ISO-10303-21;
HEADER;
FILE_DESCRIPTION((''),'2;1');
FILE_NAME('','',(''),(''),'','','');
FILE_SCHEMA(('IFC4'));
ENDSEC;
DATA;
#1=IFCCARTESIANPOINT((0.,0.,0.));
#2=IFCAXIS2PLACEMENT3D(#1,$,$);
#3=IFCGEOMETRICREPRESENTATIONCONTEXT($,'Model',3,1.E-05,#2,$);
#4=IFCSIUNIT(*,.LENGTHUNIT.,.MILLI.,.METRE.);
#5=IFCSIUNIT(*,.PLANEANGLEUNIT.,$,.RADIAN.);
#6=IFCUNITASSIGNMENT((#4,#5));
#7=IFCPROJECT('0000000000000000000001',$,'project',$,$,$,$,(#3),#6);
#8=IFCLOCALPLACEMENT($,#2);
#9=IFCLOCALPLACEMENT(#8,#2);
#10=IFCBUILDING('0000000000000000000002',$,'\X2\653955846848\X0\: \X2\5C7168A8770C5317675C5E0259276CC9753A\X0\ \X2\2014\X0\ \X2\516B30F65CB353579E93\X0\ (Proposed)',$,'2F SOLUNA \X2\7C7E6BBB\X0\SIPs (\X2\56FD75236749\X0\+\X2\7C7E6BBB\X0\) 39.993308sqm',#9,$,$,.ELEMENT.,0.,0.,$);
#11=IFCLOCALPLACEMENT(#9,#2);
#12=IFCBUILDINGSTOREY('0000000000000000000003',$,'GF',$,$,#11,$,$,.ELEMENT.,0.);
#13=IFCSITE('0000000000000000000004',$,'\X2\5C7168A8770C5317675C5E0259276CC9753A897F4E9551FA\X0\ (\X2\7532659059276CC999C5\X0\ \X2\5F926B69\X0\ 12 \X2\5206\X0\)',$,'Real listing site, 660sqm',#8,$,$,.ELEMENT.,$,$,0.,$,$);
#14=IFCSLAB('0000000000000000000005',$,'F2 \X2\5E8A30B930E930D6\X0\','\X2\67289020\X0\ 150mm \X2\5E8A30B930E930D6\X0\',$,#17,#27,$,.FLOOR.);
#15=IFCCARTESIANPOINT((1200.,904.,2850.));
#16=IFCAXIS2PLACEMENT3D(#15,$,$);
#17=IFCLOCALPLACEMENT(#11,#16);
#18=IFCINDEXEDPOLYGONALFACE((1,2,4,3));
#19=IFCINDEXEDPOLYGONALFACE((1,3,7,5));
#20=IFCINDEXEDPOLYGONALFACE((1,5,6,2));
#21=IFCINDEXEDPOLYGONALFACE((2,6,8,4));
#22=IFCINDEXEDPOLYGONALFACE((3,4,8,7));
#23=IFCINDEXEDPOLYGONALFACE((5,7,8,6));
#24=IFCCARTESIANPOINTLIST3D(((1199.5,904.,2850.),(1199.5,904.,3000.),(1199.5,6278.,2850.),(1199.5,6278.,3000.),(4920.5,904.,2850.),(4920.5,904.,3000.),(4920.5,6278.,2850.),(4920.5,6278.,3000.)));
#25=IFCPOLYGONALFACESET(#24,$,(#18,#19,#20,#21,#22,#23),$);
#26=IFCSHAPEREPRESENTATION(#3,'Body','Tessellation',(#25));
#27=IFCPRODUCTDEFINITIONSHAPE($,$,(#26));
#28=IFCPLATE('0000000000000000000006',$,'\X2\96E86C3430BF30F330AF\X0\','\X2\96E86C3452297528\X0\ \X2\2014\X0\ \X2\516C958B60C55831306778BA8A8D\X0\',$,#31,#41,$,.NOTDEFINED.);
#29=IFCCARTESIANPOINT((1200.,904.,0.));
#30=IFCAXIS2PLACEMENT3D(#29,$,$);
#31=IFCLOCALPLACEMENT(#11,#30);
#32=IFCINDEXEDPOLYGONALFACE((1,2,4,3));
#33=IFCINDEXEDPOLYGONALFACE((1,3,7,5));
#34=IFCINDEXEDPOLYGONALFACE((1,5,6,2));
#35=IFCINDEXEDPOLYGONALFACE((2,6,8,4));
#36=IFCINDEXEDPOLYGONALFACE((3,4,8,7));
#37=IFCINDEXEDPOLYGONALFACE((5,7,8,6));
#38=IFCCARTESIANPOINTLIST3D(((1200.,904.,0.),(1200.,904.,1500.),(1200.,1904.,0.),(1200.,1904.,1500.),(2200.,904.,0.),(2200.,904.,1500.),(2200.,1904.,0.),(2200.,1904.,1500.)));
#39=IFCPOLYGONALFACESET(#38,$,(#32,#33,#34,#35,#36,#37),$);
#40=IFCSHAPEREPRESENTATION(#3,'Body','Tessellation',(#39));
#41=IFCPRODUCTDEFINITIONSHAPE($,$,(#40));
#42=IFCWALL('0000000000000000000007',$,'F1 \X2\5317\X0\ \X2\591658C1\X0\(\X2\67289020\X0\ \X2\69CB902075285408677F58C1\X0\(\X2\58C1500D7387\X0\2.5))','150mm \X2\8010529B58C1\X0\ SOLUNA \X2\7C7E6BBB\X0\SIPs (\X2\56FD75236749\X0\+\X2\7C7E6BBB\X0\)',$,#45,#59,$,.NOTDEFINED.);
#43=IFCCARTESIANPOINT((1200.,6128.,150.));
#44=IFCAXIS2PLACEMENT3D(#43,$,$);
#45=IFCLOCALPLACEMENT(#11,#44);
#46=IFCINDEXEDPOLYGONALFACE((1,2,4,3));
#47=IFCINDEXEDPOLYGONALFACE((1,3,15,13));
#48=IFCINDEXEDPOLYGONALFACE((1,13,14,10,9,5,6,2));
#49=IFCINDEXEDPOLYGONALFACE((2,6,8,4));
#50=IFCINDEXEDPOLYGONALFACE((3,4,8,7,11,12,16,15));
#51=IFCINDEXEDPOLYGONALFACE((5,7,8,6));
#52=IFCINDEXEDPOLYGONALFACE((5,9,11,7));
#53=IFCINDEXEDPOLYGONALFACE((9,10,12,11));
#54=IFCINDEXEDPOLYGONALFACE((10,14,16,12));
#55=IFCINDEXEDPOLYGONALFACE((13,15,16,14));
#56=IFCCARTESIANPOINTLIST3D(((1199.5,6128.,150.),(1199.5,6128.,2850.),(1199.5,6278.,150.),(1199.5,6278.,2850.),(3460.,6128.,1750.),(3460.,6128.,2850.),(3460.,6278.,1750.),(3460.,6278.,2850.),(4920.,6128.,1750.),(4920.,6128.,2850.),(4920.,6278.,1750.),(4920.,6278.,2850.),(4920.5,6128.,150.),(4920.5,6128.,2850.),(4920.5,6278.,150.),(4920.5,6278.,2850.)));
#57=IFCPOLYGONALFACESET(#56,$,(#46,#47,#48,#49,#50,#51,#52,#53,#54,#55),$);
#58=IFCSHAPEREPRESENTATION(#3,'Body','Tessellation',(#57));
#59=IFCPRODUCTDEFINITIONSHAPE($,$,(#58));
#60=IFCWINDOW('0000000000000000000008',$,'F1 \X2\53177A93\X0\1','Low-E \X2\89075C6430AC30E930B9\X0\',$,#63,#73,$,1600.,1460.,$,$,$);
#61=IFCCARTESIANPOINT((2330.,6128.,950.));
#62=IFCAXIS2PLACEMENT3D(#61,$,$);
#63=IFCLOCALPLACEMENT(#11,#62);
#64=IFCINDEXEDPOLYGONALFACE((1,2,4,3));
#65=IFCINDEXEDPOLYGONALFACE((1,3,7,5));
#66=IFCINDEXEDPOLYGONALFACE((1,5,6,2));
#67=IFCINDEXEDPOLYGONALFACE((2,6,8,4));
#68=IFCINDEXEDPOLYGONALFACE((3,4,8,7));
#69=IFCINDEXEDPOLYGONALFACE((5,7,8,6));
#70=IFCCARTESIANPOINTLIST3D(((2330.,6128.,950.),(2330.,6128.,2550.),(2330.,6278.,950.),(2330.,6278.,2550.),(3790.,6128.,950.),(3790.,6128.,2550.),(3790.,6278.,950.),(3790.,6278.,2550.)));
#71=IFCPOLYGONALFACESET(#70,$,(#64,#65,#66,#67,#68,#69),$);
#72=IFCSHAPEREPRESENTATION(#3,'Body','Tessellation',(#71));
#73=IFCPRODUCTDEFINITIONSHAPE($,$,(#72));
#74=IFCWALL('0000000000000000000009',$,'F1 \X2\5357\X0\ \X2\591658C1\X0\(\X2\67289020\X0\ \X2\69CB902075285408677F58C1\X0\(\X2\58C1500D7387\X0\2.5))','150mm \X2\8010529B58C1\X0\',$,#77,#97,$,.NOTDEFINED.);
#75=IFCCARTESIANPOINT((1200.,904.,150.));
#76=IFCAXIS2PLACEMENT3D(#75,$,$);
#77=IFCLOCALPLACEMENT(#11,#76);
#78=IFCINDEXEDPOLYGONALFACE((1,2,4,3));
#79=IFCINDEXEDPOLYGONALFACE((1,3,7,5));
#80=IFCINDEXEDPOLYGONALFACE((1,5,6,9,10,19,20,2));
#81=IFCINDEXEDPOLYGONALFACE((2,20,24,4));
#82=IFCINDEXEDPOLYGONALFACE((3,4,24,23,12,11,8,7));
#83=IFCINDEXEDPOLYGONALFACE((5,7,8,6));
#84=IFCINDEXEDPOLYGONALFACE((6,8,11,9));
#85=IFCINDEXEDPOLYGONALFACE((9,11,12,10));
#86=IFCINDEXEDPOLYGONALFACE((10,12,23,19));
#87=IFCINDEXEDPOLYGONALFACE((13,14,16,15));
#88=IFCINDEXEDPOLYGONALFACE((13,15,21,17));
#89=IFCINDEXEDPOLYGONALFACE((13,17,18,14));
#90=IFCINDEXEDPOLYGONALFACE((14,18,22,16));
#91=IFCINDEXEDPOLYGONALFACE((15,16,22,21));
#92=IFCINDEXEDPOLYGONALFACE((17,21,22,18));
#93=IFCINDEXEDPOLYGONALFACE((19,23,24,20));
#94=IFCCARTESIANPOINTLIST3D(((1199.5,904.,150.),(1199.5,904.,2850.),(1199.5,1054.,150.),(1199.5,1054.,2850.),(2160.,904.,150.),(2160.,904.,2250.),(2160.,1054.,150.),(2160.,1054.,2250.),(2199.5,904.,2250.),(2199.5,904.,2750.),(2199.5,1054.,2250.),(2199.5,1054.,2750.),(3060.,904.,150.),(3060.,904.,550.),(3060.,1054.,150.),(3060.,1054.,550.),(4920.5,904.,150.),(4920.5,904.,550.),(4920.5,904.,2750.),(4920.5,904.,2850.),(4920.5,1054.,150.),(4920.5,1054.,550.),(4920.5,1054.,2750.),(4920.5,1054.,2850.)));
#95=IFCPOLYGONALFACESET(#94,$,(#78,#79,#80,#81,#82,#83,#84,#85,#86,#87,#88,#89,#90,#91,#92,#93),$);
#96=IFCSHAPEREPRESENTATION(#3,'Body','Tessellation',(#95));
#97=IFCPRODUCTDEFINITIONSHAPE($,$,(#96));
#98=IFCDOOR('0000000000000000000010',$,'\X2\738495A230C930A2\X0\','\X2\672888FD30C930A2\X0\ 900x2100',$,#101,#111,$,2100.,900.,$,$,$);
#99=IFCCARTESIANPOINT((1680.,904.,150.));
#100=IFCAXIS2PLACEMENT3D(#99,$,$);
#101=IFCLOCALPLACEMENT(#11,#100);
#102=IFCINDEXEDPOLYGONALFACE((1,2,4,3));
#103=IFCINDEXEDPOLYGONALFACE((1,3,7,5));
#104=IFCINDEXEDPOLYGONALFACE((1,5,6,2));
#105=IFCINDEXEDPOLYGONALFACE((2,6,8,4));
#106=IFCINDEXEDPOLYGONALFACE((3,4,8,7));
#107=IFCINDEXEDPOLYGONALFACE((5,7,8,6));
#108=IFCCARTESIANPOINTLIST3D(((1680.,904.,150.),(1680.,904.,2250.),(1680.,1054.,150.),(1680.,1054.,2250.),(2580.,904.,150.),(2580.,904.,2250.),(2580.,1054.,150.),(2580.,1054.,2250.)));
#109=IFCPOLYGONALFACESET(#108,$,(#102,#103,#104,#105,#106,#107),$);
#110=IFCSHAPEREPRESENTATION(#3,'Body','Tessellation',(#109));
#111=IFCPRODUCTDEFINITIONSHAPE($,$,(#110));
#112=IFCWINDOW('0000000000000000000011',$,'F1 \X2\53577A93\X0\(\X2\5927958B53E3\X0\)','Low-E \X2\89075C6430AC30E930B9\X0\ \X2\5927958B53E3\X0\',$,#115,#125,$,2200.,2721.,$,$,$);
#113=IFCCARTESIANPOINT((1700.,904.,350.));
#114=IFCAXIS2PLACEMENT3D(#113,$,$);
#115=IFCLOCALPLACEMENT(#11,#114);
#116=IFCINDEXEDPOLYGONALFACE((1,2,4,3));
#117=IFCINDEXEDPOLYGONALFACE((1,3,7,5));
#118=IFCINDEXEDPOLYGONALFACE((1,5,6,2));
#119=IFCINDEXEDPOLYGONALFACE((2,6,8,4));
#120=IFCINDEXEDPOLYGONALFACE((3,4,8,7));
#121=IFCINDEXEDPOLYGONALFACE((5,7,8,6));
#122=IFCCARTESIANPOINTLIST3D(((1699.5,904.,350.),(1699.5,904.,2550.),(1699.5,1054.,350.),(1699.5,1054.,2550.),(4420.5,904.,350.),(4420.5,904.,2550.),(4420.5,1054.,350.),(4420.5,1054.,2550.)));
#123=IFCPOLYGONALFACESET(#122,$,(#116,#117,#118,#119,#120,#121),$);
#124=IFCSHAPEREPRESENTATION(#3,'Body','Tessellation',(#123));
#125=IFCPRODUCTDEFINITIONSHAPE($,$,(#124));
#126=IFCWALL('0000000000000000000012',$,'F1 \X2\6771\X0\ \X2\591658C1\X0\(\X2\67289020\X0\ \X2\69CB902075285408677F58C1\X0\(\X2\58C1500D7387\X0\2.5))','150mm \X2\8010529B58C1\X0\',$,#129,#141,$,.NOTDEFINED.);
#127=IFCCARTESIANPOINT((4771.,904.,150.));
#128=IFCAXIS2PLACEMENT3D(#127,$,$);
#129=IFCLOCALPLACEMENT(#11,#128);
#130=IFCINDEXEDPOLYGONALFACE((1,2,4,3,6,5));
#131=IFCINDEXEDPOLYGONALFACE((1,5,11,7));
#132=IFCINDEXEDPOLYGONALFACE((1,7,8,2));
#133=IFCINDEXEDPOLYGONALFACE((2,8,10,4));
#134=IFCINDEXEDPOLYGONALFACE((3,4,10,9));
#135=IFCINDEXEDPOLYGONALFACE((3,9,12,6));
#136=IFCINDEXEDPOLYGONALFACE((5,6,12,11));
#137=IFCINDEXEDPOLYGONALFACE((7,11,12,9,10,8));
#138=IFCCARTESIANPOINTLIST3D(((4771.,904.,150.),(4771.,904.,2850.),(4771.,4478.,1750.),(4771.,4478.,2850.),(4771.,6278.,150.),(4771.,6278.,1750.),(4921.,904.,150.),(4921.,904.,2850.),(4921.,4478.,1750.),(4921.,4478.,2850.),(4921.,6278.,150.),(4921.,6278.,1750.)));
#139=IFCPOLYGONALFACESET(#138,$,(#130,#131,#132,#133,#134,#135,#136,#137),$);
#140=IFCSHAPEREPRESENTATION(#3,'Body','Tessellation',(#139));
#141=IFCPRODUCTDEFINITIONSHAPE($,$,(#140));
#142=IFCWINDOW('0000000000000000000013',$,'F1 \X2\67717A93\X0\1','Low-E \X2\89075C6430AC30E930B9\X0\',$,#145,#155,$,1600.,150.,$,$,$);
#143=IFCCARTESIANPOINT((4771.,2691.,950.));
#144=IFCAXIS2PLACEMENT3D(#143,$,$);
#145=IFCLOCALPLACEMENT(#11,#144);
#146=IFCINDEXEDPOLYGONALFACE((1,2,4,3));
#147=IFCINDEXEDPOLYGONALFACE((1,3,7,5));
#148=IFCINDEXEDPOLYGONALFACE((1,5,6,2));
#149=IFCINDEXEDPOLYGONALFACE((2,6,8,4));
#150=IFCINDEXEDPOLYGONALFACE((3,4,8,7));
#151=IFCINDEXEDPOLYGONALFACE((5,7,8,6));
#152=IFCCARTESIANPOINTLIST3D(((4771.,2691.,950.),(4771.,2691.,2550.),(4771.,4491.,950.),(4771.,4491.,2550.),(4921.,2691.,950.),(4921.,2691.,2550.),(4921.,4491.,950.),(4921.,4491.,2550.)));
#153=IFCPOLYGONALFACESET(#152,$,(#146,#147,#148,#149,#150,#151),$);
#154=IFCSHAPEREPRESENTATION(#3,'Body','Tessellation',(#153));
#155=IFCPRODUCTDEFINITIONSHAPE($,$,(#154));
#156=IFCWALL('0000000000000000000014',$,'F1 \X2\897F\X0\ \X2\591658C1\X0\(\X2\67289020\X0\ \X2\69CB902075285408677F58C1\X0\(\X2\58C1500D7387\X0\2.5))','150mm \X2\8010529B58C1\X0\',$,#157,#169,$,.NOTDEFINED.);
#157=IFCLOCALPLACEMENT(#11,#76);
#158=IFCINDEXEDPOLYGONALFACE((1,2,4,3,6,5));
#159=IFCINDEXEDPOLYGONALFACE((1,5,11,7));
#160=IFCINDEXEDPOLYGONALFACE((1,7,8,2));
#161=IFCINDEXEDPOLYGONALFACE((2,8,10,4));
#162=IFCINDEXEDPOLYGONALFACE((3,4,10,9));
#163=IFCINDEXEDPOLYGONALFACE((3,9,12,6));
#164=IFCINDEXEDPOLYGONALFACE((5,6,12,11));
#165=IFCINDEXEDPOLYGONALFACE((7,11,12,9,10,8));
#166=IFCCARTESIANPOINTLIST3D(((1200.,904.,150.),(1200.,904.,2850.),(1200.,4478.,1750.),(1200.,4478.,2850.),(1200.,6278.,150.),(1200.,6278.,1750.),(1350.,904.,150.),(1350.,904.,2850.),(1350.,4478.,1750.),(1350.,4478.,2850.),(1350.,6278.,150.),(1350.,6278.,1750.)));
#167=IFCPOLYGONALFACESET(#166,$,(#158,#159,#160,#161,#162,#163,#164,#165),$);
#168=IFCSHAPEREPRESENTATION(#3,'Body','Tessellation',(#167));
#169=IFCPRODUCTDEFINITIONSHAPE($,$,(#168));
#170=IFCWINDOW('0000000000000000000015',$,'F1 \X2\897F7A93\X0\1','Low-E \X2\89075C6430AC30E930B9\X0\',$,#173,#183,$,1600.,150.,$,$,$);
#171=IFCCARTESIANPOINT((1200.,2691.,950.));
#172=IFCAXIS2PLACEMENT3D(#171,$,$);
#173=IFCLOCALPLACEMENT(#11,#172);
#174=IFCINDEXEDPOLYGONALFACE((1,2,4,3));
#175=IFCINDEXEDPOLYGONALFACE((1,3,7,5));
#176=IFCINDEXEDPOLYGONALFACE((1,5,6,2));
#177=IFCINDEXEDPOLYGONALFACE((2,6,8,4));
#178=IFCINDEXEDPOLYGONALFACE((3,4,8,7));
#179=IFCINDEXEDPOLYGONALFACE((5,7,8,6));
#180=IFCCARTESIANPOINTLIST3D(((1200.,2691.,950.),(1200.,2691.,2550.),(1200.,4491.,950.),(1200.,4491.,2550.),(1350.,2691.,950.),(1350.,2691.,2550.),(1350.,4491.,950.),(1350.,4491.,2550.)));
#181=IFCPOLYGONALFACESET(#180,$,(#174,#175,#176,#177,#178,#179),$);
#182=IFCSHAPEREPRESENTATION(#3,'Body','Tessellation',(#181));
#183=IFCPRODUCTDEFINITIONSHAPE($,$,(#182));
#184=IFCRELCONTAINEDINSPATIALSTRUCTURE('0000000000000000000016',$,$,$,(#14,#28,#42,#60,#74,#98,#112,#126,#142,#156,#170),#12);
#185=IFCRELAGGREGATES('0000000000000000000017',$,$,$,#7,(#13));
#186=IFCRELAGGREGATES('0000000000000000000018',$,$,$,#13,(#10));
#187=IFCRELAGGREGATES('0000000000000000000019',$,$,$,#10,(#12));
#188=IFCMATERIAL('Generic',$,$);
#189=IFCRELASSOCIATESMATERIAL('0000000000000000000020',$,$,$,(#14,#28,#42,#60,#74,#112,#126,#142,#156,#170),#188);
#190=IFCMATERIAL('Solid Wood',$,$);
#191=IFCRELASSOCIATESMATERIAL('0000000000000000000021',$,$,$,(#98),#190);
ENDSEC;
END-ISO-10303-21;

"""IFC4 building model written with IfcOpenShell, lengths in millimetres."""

from ifc_helpers import new_model, si_unit, frame, frame_2d, origin, place, context, project, spatial, rectangle, extrude, material, element, fill, save


model = new_model("IFC4")

# Units and contexts
model_context = context("Model", 3, precision=1e-05, world=origin())
ifc_project = project(units=[si_unit("LENGTHUNIT", "METRE", prefix="MILLI"), si_unit("PLANEANGLEUNIT", "RADIAN")], contexts=[model_context])

# Site, building, storey
site_placement = place(None, origin())
site = spatial("IfcSite", under=ifc_project, at=site_placement, Name="山梨県北杜市大泉町西井出 (甲斐大泉駅 徒歩 12 分)", ObjectType="Real listing site, 660sqm", CompositionType="ELEMENT", RefElevation=0.0)
building_placement = place(site_placement, origin())
building = spatial("IfcBuilding", under=site, at=building_placement, Name="改善案: 山梨県北杜市大泉町 — 八ヶ岳南麓 (Proposed)", ObjectType="2F SOLUNA 籾殻SIPs (国産杉+籾殻) 39.993308sqm", CompositionType="ELEMENT", ElevationOfRefHeight=0.0, ElevationOfTerrain=0.0)
storey_placement = place(building_placement, origin())
storey = spatial("IfcBuildingStorey", under=building, at=storey_placement, Name="GF", CompositionType="ELEMENT", Elevation=0.0)

# Slab
ifc_material_1 = material(Name="Generic")
slab_1_placement = place(storey_placement, frame((1200.0, 904.0, 2850.0)))
element("IfcSlab", 1, at=slab_1_placement, inside=storey, material=ifc_material_1, Name="F2 床スラブ", Description="木造 150mm 床スラブ", PredefinedType="FLOOR", context=model_context, shape_type="SweptSolid", body=[
    extrude(rectangle(XDim=3721.0, YDim=5374.0, at=frame_2d((1860.0, 2687.0))), frame((1200.0, 904.0, 2850.0)), (0.0, 0.0, 1.0), 150.0),
])

# Plate
plate_placement = place(storey_placement, frame((1200.0, 904.0, 0.0)))
element("IfcPlate", 2, at=plate_placement, inside=storey, material=ifc_material_1, Name="雨水タンク", Description="雨水利用 — 公開情報で確認", PredefinedType="NOTDEFINED", context=model_context, shape_type="SweptSolid", body=[
    extrude(rectangle(XDim=1000.0, YDim=1000.0, at=frame_2d((500.0, 500.0))), frame((1200.0, 904.0, 0.0)), (0.0, 0.0, 1.0), 1500.0),
])

# Wall, opening, window
wall_1_placement = place(storey_placement, frame((1200.0, 6128.0, 150.0)))
wall_1 = element("IfcWall", 3, at=wall_1_placement, inside=storey, material=ifc_material_1, Name="F1 北 外壁(木造 構造用合板壁(壁倍率2.5))", Description="150mm 耐力壁 SOLUNA 籾殻SIPs (国産杉+籾殻)", PredefinedType="NOTDEFINED", context=model_context, shape_type="SweptSolid", body=[
    extrude(rectangle(XDim=3721.0, YDim=150.0, at=frame_2d((1860.0, 75.0))), frame((1200.0, 6128.0, 150.0)), (0.0, 0.0, 1.0), 2700.0),
])
opening_1_placement = place(storey_placement, frame((2330.0, 6128.0, 950.0)))
opening_1 = element("IfcOpeningElement", 4, at=opening_1_placement, cuts=wall_1, PredefinedType="NOTDEFINED", context=model_context, shape_type="SweptSolid", body=[
    extrude(rectangle(XDim=1460.0, YDim=150.0, at=frame_2d((730.0, 75.0))), frame((2330.0, 6128.0, 950.0)), (0.0, 0.0, 1.0), 1600.0),
])
window_1_placement = place(storey_placement, frame((2330.0, 6128.0, 950.0)))
window_1 = element("IfcWindow", 5, at=window_1_placement, inside=storey, material=ifc_material_1, Name="F1 北窓1", Description="Low-E 複層ガラス", OverallHeight=1600.0, OverallWidth=1460.0, context=model_context, shape_type="SweptSolid", body=[
    extrude(rectangle(XDim=1460.0, YDim=150.0, at=frame_2d((730.0, 75.0))), frame((2330.0, 6128.0, 950.0)), (0.0, 0.0, 1.0), 1600.0),
])
fill(opening_1, window_1)

# Wall, openings, door, window
wall_2_placement = place(storey_placement, frame((1200.0, 904.0, 150.0)))
wall_2 = element("IfcWall", 6, at=wall_2_placement, inside=storey, material=ifc_material_1, Name="F1 南 外壁(木造 構造用合板壁(壁倍率2.5))", Description="150mm 耐力壁", PredefinedType="NOTDEFINED", context=model_context, shape_type="SweptSolid", body=[
    extrude(rectangle(XDim=3721.0, YDim=150.0, at=frame_2d((1860.0, 75.0))), frame((1200.0, 904.0, 150.0)), (0.0, 0.0, 1.0), 2700.0),
])
opening_2_placement = place(storey_placement, frame((1680.0, 904.0, 150.0)))
opening_2 = element("IfcOpeningElement", 7, at=opening_2_placement, cuts=wall_2, PredefinedType="NOTDEFINED", context=model_context, shape_type="SweptSolid", body=[
    extrude(rectangle(XDim=900.0, YDim=150.0, at=frame_2d((450.0, 75.0))), frame((1680.0, 904.0, 150.0)), (0.0, 0.0, 1.0), 2100.0),
])
opening_3_placement = place(storey_placement, frame((1700.0, 904.0, 350.0)))
opening_3 = element("IfcOpeningElement", 8, at=opening_3_placement, cuts=wall_2, PredefinedType="NOTDEFINED", context=model_context, shape_type="SweptSolid", body=[
    extrude(rectangle(XDim=2721.0, YDim=150.0, at=frame_2d((1360.0, 75.0))), frame((1700.0, 904.0, 350.0)), (0.0, 0.0, 1.0), 2200.0),
])
ifc_material_2 = material(Name="Solid Wood")
door_placement = place(storey_placement, frame((1680.0, 904.0, 150.0)))
door = element("IfcDoor", 9, at=door_placement, inside=storey, material=ifc_material_2, Name="玄関ドア", Description="木製ドア 900x2100", OverallHeight=2100.0, OverallWidth=900.0, context=model_context, shape_type="SweptSolid", body=[
    extrude(rectangle(XDim=900.0, YDim=150.0, at=frame_2d((450.0, 75.0))), frame((1680.0, 904.0, 150.0)), (0.0, 0.0, 1.0), 2100.0),
])
fill(opening_2, door)
window_2_placement = place(storey_placement, frame((1700.0, 904.0, 350.0)))
window_2 = element("IfcWindow", 10, at=window_2_placement, inside=storey, material=ifc_material_1, Name="F1 南窓(大開口)", Description="Low-E 複層ガラス 大開口", OverallHeight=2200.0, OverallWidth=2721.0, context=model_context, shape_type="SweptSolid", body=[
    extrude(rectangle(XDim=2721.0, YDim=150.0, at=frame_2d((1360.0, 75.0))), frame((1700.0, 904.0, 350.0)), (0.0, 0.0, 1.0), 2200.0),
])
fill(opening_3, window_2)

# Walls, openings, windows
wall_3_placement = place(storey_placement, frame((4771.0, 904.0, 150.0)))
wall_3 = element("IfcWall", 11, at=wall_3_placement, inside=storey, material=ifc_material_1, Name="F1 東 外壁(木造 構造用合板壁(壁倍率2.5))", Description="150mm 耐力壁", PredefinedType="NOTDEFINED", context=model_context, shape_type="SweptSolid", body=[
    extrude(rectangle(XDim=150.0, YDim=5374.0, at=frame_2d((75.0, 2687.0))), frame((4771.0, 904.0, 150.0)), (0.0, 0.0, 1.0), 2700.0),
])
opening_4_placement = place(storey_placement, frame((4771.0, 2691.0, 950.0)))
opening_4 = element("IfcOpeningElement", 12, at=opening_4_placement, cuts=wall_3, PredefinedType="NOTDEFINED", context=model_context, shape_type="SweptSolid", body=[
    extrude(rectangle(XDim=150.0, YDim=1800.0, at=frame_2d((75.0, 900.0))), frame((4771.0, 2691.0, 950.0)), (0.0, 0.0, 1.0), 1600.0),
])
window_3_placement = place(storey_placement, frame((4771.0, 2691.0, 950.0)))
window_3 = element("IfcWindow", 13, at=window_3_placement, inside=storey, material=ifc_material_1, Name="F1 東窓1", Description="Low-E 複層ガラス", OverallHeight=1600.0, OverallWidth=150.0, context=model_context, shape_type="SweptSolid", body=[
    extrude(rectangle(XDim=150.0, YDim=1800.0, at=frame_2d((75.0, 900.0))), frame((4771.0, 2691.0, 950.0)), (0.0, 0.0, 1.0), 1600.0),
])
fill(opening_4, window_3)
wall_4_placement = place(storey_placement, frame((1200.0, 904.0, 150.0)))
wall_4 = element("IfcWall", 14, at=wall_4_placement, inside=storey, material=ifc_material_1, Name="F1 西 外壁(木造 構造用合板壁(壁倍率2.5))", Description="150mm 耐力壁", PredefinedType="NOTDEFINED", context=model_context, shape_type="SweptSolid", body=[
    extrude(rectangle(XDim=150.0, YDim=5374.0, at=frame_2d((75.0, 2687.0))), frame((1200.0, 904.0, 150.0)), (0.0, 0.0, 1.0), 2700.0),
])
opening_5_placement = place(storey_placement, frame((1200.0, 2691.0, 950.0)))
opening_5 = element("IfcOpeningElement", 15, at=opening_5_placement, cuts=wall_4, PredefinedType="NOTDEFINED", context=model_context, shape_type="SweptSolid", body=[
    extrude(rectangle(XDim=150.0, YDim=1800.0, at=frame_2d((75.0, 900.0))), frame((1200.0, 2691.0, 950.0)), (0.0, 0.0, 1.0), 1600.0),
])
window_4_placement = place(storey_placement, frame((1200.0, 2691.0, 950.0)))
window_4 = element("IfcWindow", 16, at=window_4_placement, inside=storey, material=ifc_material_1, Name="F1 西窓1", Description="Low-E 複層ガラス", OverallHeight=1600.0, OverallWidth=150.0, context=model_context, shape_type="SweptSolid", body=[
    extrude(rectangle(XDim=150.0, YDim=1800.0, at=frame_2d((75.0, 900.0))), frame((1200.0, 2691.0, 950.0)), (0.0, 0.0, 1.0), 1600.0),
])
fill(opening_5, window_4)

save(model, "model.ifc")
